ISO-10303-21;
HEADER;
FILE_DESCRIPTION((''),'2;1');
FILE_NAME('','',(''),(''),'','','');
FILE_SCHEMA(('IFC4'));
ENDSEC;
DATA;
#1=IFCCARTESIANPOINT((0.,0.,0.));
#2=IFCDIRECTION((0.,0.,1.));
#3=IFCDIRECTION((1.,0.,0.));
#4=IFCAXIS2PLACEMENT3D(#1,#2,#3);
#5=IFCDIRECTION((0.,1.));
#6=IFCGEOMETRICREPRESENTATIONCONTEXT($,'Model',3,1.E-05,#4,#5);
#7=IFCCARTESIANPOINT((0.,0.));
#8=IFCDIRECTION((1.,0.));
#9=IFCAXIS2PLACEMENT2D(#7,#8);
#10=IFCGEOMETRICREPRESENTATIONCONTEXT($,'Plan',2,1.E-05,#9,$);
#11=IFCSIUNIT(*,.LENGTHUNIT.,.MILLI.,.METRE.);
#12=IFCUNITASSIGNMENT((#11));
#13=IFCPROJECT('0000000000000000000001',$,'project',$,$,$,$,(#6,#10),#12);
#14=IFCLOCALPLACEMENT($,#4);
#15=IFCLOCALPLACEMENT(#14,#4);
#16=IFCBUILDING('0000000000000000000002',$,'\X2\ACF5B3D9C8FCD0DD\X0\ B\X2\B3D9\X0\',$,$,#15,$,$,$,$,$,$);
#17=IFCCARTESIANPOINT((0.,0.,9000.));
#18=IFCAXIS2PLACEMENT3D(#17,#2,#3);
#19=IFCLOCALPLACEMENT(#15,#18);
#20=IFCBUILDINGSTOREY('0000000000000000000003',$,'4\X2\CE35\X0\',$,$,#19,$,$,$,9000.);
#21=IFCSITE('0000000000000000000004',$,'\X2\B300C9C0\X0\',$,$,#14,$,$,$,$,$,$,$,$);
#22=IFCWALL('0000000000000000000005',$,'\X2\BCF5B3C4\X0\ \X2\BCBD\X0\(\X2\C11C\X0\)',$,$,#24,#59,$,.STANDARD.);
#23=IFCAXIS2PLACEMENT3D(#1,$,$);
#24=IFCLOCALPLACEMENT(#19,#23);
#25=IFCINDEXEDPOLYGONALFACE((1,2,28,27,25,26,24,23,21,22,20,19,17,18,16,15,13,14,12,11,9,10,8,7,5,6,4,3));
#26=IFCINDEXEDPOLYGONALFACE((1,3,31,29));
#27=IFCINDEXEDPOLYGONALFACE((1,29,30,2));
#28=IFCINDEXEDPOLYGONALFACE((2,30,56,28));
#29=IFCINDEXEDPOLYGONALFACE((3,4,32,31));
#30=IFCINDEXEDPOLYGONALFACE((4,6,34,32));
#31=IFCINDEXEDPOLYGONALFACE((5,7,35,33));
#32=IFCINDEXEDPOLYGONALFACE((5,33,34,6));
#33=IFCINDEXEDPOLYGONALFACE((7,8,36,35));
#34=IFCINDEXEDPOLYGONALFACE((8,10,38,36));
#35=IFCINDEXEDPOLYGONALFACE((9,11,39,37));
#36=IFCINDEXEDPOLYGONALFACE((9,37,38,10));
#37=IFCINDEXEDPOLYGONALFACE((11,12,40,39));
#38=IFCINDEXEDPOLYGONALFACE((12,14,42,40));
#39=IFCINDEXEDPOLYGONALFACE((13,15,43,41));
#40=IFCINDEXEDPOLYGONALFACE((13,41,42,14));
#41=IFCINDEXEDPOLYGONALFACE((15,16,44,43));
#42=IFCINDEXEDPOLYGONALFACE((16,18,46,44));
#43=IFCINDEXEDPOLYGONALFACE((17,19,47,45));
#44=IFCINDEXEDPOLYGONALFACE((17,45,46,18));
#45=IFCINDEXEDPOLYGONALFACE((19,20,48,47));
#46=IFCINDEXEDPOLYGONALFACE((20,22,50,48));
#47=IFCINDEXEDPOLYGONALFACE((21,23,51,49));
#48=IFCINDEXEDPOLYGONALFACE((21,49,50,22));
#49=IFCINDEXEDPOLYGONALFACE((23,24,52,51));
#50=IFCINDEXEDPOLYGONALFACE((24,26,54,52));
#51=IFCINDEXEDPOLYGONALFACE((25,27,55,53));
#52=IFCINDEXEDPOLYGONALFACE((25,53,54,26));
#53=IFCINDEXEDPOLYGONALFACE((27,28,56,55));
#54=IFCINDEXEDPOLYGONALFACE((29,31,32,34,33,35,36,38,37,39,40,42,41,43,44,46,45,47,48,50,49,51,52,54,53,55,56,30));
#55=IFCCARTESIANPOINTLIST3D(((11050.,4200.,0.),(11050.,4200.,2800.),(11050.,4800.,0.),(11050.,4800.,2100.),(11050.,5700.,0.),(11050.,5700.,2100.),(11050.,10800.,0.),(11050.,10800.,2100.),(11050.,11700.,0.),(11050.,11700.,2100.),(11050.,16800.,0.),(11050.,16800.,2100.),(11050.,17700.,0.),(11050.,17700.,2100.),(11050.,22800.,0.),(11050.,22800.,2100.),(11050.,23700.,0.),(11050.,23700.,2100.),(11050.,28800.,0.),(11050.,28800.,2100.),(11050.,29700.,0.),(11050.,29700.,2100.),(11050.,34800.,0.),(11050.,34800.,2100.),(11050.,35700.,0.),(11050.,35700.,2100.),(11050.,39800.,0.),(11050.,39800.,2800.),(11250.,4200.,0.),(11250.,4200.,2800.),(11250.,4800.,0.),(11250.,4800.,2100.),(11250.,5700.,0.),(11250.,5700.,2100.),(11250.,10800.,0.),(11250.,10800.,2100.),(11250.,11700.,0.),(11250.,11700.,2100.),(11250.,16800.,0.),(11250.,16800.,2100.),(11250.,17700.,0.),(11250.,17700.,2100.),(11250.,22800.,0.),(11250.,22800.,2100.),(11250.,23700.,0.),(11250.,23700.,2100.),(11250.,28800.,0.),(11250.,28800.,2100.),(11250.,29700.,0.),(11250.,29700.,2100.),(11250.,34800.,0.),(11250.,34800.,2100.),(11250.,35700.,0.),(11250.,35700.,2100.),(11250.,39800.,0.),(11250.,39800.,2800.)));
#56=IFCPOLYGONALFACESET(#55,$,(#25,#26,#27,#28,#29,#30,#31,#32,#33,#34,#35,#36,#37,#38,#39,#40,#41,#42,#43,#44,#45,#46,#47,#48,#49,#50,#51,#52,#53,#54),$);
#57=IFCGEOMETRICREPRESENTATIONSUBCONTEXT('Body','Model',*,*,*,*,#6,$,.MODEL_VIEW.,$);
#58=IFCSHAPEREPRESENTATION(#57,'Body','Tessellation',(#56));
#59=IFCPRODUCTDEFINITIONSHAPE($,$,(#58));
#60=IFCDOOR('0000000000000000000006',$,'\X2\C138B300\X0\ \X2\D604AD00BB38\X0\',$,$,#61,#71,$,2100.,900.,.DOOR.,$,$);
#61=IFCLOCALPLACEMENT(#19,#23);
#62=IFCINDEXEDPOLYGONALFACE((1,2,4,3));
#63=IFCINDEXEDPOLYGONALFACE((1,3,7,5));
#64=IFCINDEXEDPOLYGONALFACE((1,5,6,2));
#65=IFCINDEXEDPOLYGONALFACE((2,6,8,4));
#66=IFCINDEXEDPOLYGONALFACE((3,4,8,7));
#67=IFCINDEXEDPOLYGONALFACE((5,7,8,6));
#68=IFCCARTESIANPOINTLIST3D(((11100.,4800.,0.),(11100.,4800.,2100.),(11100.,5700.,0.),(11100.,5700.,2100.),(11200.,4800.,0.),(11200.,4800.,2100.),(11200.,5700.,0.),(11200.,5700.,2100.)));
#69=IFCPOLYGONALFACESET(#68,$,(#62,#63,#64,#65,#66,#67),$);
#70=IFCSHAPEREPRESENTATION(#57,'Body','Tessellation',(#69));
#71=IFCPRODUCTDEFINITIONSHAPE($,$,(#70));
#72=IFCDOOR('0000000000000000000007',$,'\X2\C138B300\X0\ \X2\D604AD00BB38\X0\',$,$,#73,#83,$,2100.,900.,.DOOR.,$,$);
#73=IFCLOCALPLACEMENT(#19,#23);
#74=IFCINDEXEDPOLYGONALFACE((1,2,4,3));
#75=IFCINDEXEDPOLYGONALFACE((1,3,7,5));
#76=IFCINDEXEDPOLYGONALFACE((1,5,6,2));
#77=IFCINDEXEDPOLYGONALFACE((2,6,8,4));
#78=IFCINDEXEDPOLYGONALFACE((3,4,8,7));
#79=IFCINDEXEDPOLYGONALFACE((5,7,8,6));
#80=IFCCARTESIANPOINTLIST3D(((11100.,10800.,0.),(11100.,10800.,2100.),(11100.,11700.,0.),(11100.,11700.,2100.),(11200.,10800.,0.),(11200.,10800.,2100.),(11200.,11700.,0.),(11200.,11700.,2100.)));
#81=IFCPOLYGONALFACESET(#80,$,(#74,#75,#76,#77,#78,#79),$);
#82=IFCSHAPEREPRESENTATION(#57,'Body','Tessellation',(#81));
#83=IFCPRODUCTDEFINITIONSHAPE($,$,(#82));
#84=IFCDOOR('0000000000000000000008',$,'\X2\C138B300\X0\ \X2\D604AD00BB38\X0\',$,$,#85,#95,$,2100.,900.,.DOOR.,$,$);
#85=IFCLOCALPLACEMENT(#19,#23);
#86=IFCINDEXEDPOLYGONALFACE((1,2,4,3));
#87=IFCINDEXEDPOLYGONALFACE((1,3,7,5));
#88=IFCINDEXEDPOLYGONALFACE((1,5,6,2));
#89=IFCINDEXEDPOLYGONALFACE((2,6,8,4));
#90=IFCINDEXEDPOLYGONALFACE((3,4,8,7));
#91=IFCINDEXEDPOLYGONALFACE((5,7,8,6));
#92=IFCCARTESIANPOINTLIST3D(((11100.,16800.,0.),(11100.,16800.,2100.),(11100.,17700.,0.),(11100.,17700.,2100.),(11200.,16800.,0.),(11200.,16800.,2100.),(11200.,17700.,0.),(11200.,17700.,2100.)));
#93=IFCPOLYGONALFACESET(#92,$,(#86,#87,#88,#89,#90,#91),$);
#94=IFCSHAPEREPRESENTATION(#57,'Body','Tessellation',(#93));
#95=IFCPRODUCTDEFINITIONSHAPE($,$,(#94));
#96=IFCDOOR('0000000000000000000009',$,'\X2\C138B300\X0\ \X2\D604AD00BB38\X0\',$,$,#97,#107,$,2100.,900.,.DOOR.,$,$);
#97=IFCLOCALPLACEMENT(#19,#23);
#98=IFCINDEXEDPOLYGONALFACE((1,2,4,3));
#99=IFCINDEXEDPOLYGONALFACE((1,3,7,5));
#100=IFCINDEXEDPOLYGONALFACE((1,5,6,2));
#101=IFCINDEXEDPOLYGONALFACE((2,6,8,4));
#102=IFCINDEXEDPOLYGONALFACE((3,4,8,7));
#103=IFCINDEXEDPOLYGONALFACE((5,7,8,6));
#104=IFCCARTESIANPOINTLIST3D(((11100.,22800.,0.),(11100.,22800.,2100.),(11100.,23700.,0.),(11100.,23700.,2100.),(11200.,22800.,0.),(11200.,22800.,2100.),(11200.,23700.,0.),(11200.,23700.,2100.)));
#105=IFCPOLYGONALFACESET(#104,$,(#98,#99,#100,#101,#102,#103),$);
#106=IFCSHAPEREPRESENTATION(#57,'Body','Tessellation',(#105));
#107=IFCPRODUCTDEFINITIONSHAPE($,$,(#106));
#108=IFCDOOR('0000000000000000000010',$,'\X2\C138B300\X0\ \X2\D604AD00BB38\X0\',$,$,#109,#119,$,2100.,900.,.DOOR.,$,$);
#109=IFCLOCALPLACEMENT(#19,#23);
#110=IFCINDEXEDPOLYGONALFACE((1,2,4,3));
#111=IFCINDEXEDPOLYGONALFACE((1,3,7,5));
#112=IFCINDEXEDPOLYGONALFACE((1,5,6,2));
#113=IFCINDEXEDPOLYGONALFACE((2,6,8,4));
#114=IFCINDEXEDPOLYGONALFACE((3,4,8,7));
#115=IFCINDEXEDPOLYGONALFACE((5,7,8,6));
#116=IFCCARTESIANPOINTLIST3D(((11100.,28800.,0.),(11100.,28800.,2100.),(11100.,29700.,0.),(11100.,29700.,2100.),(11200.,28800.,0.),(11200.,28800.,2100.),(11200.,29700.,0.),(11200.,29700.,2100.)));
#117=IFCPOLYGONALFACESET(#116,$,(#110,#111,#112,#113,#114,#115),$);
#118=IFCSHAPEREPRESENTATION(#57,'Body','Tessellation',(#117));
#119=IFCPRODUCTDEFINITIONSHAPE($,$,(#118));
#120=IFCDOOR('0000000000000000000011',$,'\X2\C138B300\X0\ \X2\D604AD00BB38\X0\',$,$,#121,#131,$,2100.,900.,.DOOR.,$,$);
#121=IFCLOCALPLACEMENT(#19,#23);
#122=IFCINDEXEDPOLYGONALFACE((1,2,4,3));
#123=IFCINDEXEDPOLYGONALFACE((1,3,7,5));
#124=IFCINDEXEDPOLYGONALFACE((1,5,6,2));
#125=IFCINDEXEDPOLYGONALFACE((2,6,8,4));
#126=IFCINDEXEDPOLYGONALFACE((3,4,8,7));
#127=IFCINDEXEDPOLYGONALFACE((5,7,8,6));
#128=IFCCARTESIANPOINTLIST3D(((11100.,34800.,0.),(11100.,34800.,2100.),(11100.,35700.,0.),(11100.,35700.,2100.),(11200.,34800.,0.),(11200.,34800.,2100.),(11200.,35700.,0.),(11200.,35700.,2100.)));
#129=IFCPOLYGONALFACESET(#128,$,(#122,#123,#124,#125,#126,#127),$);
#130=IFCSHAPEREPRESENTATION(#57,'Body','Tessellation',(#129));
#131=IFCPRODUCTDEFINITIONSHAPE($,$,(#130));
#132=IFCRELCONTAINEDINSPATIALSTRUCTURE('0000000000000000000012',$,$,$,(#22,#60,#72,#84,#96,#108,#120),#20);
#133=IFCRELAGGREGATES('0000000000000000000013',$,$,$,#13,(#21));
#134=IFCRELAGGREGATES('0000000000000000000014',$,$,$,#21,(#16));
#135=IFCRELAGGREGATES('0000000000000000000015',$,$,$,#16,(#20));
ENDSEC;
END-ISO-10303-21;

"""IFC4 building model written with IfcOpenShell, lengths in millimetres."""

from ifc_helpers import new_model, si_unit, direction, frame, origin_with_axes, origin_2d_with_axis, place, context, subcontext, project, spatial, polyline, outline, extrude, element, fill, save


model = new_model("IFC4")

# Units and contexts
model_context = context("Model", 3, precision=1e-05, world=origin_with_axes(), true_north=direction((0.0, 1.0)))
plan_context = context("Plan", 2, precision=1e-05, world=origin_2d_with_axis())
body_context = subcontext(model_context, "Body", "Model", "MODEL_VIEW")
ifc_project = project(units=[si_unit("LENGTHUNIT", "METRE", prefix="MILLI")], contexts=[model_context, plan_context])

# Site, building, storey
site_placement = place(None, origin_with_axes())
site = spatial("IfcSite", under=ifc_project, at=site_placement, Name="대지")
building_placement = place(site_placement, origin_with_axes())
building = spatial("IfcBuilding", under=site, at=building_placement, Name="공동주택 B동")
storey_placement = place(building_placement, frame((0.0, 0.0, 9000.0), z_axis=(0.0, 0.0, 1.0), x_axis=(1.0, 0.0, 0.0)))
storey = spatial("IfcBuildingStorey", under=building, at=storey_placement, Name="4층", Elevation=9000.0)

# Wall, openings, doors
wall_1_placement = place(storey_placement, origin_with_axes())
wall_1 = element("IfcWall", 1, at=wall_1_placement, inside=storey, Name="복도 벽(서)", PredefinedType="STANDARD", context=body_context, shape_type="SweptSolid", body=[
    extrude(outline(polyline([(11050.0, 4200.0), (11050.0, 39800.0), (11250.0, 39800.0), (11250.0, 4200.0), (11050.0, 4200.0)])), origin_with_axes(), (0.0, 0.0, 1.0), 2800.0),
])
opening_1_placement = place(storey_placement, origin_with_axes())
opening_1 = element("IfcOpeningElement", 2, at=opening_1_placement, cuts=wall_1, PredefinedType="OPENING", context=body_context, shape_type="SweptSolid", body=[
    extrude(outline(polyline([(11300.0, 4800.0), (11300.0, 5700.0), (11000.0, 5700.0), (11000.0, 4800.0), (11300.0, 4800.0)])), origin_with_axes(), (0.0, 0.0, 1.0), 2100.0),
])
opening_2_placement = place(storey_placement, origin_with_axes())
opening_2 = element("IfcOpeningElement", 3, at=opening_2_placement, cuts=wall_1, PredefinedType="OPENING", context=body_context, shape_type="SweptSolid", body=[
    extrude(outline(polyline([(11300.0, 10800.0), (11300.0, 11700.0), (11000.0, 11700.0), (11000.0, 10800.0), (11300.0, 10800.0)])), origin_with_axes(), (0.0, 0.0, 1.0), 2100.0),
])
opening_3_placement = place(storey_placement, origin_with_axes())
opening_3 = element("IfcOpeningElement", 4, at=opening_3_placement, cuts=wall_1, PredefinedType="OPENING", context=body_context, shape_type="SweptSolid", body=[
    extrude(outline(polyline([(11300.0, 16800.0), (11300.0, 17700.0), (11000.0, 17700.0), (11000.0, 16800.0), (11300.0, 16800.0)])), origin_with_axes(), (0.0, 0.0, 1.0), 2100.0),
])
opening_4_placement = place(storey_placement, origin_with_axes())
opening_4 = element("IfcOpeningElement", 5, at=opening_4_placement, cuts=wall_1, PredefinedType="OPENING", context=body_context, shape_type="SweptSolid", body=[
    extrude(outline(polyline([(11300.0, 22800.0), (11300.0, 23700.0), (11000.0, 23700.0), (11000.0, 22800.0), (11300.0, 22800.0)])), origin_with_axes(), (0.0, 0.0, 1.0), 2100.0),
])
opening_5_placement = place(storey_placement, origin_with_axes())
opening_5 = element("IfcOpeningElement", 6, at=opening_5_placement, cuts=wall_1, PredefinedType="OPENING", context=body_context, shape_type="SweptSolid", body=[
    extrude(outline(polyline([(11300.0, 28800.0), (11300.0, 29700.0), (11000.0, 29700.0), (11000.0, 28800.0), (11300.0, 28800.0)])), origin_with_axes(), (0.0, 0.0, 1.0), 2100.0),
])
opening_6_placement = place(storey_placement, origin_with_axes())
opening_6 = element("IfcOpeningElement", 7, at=opening_6_placement, cuts=wall_1, PredefinedType="OPENING", context=body_context, shape_type="SweptSolid", body=[
    extrude(outline(polyline([(11300.0, 34800.0), (11300.0, 35700.0), (11000.0, 35700.0), (11000.0, 34800.0), (11300.0, 34800.0)])), origin_with_axes(), (0.0, 0.0, 1.0), 2100.0),
])
door_1_placement = place(storey_placement, origin_with_axes())
door_1 = element("IfcDoor", 8, at=door_1_placement, inside=storey, Name="세대 현관문", OverallHeight=2100.0, OverallWidth=900.0, PredefinedType="DOOR", context=body_context, shape_type="SweptSolid", body=[
    extrude(outline(polyline([(11200.0, 4800.0), (11200.0, 5700.0), (11100.0, 5700.0), (11100.0, 4800.0), (11200.0, 4800.0)])), origin_with_axes(), (0.0, 0.0, 1.0), 2100.0),
])
fill(opening_1, door_1)
door_2_placement = place(storey_placement, origin_with_axes())
door_2 = element("IfcDoor", 9, at=door_2_placement, inside=storey, Name="세대 현관문", OverallHeight=2100.0, OverallWidth=900.0, PredefinedType="DOOR", context=body_context, shape_type="SweptSolid", body=[
    extrude(outline(polyline([(11200.0, 10800.0), (11200.0, 11700.0), (11100.0, 11700.0), (11100.0, 10800.0), (11200.0, 10800.0)])), origin_with_axes(), (0.0, 0.0, 1.0), 2100.0),
])
fill(opening_2, door_2)
door_3_placement = place(storey_placement, origin_with_axes())
door_3 = element("IfcDoor", 10, at=door_3_placement, inside=storey, Name="세대 현관문", OverallHeight=2100.0, OverallWidth=900.0, PredefinedType="DOOR", context=body_context, shape_type="SweptSolid", body=[
    extrude(outline(polyline([(11200.0, 16800.0), (11200.0, 17700.0), (11100.0, 17700.0), (11100.0, 16800.0), (11200.0, 16800.0)])), origin_with_axes(), (0.0, 0.0, 1.0), 2100.0),
])
fill(opening_3, door_3)
door_4_placement = place(storey_placement, origin_with_axes())
door_4 = element("IfcDoor", 11, at=door_4_placement, inside=storey, Name="세대 현관문", OverallHeight=2100.0, OverallWidth=900.0, PredefinedType="DOOR", context=body_context, shape_type="SweptSolid", body=[
    extrude(outline(polyline([(11200.0, 22800.0), (11200.0, 23700.0), (11100.0, 23700.0), (11100.0, 22800.0), (11200.0, 22800.0)])), origin_with_axes(), (0.0, 0.0, 1.0), 2100.0),
])
fill(opening_4, door_4)
door_5_placement = place(storey_placement, origin_with_axes())
door_5 = element("IfcDoor", 12, at=door_5_placement, inside=storey, Name="세대 현관문", OverallHeight=2100.0, OverallWidth=900.0, PredefinedType="DOOR", context=body_context, shape_type="SweptSolid", body=[
    extrude(outline(polyline([(11200.0, 28800.0), (11200.0, 29700.0), (11100.0, 29700.0), (11100.0, 28800.0), (11200.0, 28800.0)])), origin_with_axes(), (0.0, 0.0, 1.0), 2100.0),
])
fill(opening_5, door_5)
door_6_placement = place(storey_placement, origin_with_axes())
door_6 = element("IfcDoor", 13, at=door_6_placement, inside=storey, Name="세대 현관문", OverallHeight=2100.0, OverallWidth=900.0, PredefinedType="DOOR", context=body_context, shape_type="SweptSolid", body=[
    extrude(outline(polyline([(11200.0, 34800.0), (11200.0, 35700.0), (11100.0, 35700.0), (11100.0, 34800.0), (11200.0, 34800.0)])), origin_with_axes(), (0.0, 0.0, 1.0), 2100.0),
])
fill(opening_6, door_6)

save(model, "model.ifc")
